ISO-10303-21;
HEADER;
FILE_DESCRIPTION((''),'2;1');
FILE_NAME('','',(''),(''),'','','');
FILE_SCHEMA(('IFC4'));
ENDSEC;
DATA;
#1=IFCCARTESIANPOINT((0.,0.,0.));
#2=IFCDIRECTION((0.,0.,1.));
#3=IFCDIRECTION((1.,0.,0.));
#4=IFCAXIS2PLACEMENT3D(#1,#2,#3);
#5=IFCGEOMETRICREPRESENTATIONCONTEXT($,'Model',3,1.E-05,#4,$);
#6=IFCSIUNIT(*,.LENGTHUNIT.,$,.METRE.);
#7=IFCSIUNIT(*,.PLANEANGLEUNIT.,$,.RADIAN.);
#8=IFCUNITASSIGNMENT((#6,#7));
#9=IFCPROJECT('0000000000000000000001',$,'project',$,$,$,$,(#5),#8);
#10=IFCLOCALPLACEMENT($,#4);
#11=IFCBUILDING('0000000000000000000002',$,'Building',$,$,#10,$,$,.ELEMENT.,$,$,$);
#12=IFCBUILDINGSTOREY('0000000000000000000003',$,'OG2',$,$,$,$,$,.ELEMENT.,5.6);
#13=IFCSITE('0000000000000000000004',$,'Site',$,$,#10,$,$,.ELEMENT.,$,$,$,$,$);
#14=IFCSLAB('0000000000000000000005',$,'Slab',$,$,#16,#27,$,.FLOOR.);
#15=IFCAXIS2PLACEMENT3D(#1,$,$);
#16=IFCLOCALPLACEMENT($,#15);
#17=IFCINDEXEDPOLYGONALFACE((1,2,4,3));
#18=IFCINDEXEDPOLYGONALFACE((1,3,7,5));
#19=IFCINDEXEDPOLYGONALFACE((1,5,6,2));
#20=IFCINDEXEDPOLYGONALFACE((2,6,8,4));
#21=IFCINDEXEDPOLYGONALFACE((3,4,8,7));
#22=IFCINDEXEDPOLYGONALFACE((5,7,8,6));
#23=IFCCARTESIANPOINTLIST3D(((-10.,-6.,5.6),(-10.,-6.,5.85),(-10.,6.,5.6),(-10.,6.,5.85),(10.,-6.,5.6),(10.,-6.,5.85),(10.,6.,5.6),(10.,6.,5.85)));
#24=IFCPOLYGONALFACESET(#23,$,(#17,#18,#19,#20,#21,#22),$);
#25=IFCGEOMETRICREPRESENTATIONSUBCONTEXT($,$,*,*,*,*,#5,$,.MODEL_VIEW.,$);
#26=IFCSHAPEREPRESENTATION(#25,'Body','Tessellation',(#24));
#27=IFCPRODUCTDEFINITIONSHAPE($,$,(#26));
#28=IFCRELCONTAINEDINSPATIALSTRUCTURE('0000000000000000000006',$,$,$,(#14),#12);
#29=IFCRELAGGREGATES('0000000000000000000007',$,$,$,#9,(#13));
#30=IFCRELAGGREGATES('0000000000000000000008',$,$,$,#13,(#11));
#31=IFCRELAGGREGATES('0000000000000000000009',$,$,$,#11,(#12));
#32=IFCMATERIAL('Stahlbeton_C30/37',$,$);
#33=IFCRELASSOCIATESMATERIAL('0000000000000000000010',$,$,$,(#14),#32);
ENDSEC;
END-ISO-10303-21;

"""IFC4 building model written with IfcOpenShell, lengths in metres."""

from ifc_helpers import new_model, si_unit, frame, frame_2d, origin, origin_with_axes, place, context, subcontext, project, spatial, rectangle, extrude, material, element, save


model = new_model("IFC4")

# Units and contexts
model_context = context("Model", 3, precision=1e-05, world=origin_with_axes())
sub_context = subcontext(model_context, None, None, "MODEL_VIEW")
ifc_project = project(units=[si_unit("LENGTHUNIT", "METRE"), si_unit("PLANEANGLEUNIT", "RADIAN")], contexts=[model_context])

# Site, building, storey
placement_1 = place(None, origin_with_axes())
site = spatial("IfcSite", under=ifc_project, at=placement_1, Name="Site", CompositionType="ELEMENT")
building = spatial("IfcBuilding", under=site, at=placement_1, Name="Building", CompositionType="ELEMENT")
storey = spatial("IfcBuildingStorey", under=building, Name="OG2", CompositionType="ELEMENT", Elevation=5.6)

# Slab
ifc_material = material(Name="Stahlbeton_C30/37")
placement_2 = place(None, origin_with_axes())
placement_3 = place(placement_2, frame((0.0, 0.0, 5.6)))
slab_placement = place(placement_3, frame((-10.0, -6.0, 0.0)))
element("IfcSlab", 1, at=slab_placement, inside=storey, material=ifc_material, Name="Slab", PredefinedType="FLOOR", context=sub_context, shape_type="SweptSolid", body=[
    extrude(rectangle(XDim=20.0, YDim=12.0, at=frame_2d((10.0, 6.0))), origin(), (0.0, 0.0, 1.0), 0.25),
])

save(model, "model.ifc")
